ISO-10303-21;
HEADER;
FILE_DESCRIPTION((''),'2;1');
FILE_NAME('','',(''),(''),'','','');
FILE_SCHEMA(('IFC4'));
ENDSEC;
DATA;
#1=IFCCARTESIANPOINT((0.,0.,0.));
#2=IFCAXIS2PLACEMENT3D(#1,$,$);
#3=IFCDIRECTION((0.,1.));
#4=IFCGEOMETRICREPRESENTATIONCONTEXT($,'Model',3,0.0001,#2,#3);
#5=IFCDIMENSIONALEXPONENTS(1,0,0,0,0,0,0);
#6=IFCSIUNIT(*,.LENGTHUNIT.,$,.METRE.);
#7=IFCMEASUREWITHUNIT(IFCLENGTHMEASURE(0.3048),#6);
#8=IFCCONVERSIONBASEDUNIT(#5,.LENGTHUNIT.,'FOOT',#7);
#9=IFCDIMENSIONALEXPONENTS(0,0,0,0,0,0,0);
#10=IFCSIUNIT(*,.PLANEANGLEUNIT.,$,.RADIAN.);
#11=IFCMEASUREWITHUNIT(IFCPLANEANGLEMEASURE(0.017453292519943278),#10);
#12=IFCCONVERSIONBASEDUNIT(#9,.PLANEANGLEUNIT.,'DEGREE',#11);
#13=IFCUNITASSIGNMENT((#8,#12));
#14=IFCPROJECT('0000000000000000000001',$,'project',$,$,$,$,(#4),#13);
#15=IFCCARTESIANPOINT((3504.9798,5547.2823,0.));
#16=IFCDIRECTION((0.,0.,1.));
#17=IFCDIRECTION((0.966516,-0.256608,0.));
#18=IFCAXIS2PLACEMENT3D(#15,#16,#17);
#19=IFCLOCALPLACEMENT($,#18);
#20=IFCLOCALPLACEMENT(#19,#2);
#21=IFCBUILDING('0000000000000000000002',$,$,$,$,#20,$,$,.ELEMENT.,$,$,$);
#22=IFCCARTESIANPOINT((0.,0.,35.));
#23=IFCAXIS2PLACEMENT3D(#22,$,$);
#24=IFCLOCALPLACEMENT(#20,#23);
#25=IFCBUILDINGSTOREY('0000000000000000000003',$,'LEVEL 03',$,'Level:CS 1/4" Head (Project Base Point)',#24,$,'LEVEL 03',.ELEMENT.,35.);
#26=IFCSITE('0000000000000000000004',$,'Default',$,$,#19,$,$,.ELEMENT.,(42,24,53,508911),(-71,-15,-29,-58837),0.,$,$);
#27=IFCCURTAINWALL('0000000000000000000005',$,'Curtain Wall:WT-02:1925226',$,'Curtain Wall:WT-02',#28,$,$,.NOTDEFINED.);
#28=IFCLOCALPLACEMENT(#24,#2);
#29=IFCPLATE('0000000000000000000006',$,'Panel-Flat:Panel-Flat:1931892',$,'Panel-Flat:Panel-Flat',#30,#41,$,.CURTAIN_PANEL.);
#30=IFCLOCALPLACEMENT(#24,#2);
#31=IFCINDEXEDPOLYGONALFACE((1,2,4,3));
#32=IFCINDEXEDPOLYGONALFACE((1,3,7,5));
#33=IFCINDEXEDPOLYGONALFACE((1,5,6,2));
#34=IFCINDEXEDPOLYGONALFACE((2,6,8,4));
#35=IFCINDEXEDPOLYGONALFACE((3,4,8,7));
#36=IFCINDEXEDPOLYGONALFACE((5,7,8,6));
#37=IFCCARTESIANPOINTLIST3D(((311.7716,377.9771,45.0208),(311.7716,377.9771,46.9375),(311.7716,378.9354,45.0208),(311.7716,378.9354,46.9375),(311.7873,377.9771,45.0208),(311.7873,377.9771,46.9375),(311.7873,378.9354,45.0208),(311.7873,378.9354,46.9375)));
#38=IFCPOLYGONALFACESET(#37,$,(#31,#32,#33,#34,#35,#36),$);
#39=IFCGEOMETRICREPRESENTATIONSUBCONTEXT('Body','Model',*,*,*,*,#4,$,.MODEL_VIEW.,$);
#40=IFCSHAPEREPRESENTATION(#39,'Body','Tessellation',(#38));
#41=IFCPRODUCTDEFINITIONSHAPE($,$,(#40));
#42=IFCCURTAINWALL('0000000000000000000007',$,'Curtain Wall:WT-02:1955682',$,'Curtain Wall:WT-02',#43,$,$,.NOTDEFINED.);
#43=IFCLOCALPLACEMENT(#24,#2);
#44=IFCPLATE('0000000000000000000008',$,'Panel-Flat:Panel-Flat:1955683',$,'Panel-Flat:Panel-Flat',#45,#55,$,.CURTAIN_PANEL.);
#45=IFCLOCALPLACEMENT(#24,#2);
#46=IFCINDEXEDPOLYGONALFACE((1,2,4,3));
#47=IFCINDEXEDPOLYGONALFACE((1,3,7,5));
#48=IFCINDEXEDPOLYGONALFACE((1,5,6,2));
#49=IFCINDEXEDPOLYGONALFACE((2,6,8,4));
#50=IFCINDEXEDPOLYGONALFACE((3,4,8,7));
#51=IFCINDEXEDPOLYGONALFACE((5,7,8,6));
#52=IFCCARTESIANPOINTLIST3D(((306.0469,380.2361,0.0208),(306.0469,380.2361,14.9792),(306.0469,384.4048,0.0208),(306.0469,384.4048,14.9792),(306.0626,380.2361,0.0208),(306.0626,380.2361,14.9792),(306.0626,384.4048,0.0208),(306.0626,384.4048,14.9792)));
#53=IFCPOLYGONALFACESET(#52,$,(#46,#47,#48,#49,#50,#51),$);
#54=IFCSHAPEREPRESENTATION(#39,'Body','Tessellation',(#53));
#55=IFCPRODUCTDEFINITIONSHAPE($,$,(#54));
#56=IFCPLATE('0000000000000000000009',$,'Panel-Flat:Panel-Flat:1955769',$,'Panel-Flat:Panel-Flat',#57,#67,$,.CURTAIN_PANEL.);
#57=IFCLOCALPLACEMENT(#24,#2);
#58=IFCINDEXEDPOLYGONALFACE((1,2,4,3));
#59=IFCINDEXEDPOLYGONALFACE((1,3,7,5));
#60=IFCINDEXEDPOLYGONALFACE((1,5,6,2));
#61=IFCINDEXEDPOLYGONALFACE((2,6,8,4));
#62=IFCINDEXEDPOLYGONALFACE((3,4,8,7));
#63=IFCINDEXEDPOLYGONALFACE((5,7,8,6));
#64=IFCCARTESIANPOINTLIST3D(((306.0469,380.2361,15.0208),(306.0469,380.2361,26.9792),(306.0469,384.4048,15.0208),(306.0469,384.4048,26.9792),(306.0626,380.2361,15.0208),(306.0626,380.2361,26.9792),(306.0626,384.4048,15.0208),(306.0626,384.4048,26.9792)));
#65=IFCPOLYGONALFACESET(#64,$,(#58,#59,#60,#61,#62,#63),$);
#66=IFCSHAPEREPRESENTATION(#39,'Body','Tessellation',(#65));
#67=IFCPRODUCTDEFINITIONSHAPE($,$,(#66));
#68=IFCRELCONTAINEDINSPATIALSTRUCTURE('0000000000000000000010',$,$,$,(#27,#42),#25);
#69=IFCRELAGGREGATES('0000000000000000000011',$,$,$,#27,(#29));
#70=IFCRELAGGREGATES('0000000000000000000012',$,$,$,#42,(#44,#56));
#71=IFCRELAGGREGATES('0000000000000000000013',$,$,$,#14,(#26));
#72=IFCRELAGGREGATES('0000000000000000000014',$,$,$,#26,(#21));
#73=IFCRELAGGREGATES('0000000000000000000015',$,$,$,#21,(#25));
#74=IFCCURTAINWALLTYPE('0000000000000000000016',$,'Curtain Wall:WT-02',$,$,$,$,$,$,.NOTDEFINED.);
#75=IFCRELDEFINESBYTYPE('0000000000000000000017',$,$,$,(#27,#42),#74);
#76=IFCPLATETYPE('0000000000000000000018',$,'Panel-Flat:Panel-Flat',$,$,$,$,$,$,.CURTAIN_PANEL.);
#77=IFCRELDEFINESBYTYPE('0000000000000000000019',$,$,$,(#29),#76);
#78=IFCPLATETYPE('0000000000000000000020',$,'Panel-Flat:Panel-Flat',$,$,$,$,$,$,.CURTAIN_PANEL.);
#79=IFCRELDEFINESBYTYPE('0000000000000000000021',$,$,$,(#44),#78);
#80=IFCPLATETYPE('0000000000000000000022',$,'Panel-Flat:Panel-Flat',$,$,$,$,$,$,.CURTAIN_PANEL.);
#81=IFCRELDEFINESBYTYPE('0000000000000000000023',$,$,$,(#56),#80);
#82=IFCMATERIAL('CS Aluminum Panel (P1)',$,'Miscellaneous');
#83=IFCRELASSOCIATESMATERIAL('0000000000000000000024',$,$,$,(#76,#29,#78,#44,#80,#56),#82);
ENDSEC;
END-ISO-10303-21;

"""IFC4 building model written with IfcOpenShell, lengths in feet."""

from ifc_helpers import new_model, entity, si_unit, converted_unit, direction, frame, origin, place, context, subcontext, project, spatial, indexed_curve, outline, extrude, source, transform, mapped, material, type_object, type_shapes, element, aggregate, save


model = new_model("IFC4")

# Units and contexts
model_context = context("Model", 3, precision=0.0001, world=origin(), true_north=direction((0.0, 1.0)))
body_context = subcontext(model_context, "Body", "Model", "MODEL_VIEW")
ifc_project = project(units=[converted_unit("LENGTHUNIT", "FOOT", entity("IfcLengthMeasure", 0.3048), si_unit("LENGTHUNIT", "METRE"), dimensions=[1, 0, 0, 0, 0, 0, 0]), converted_unit("PLANEANGLEUNIT", "DEGREE", entity("IfcPlaneAngleMeasure", 0.017453292519943278), si_unit("PLANEANGLEUNIT", "RADIAN"), dimensions=[0, 0, 0, 0, 0, 0, 0])], contexts=[model_context])

# Site, building, storey
site_placement = place(None, frame((3504.9798, 5547.2823, 0.0), z_axis=(0.0, 0.0, 1.0), x_axis=(0.966516, -0.256608, 0.0)))
site = spatial("IfcSite", under=ifc_project, at=site_placement, Name="Default", CompositionType="ELEMENT", RefLatitude=(42, 24, 53, 508911), RefLongitude=(-71, -15, -29, -58837), RefElevation=0.0)
building_placement = place(site_placement, origin())
building = spatial("IfcBuilding", under=site, at=building_placement, CompositionType="ELEMENT")
storey_placement = place(building_placement, frame((0.0, 0.0, 35.0)))
storey = spatial("IfcBuildingStorey", under=building, at=storey_placement, Name="LEVEL 03", ObjectType="Level:CS 1/4\" Head (Project Base Point)", LongName="LEVEL 03", CompositionType="ELEMENT", Elevation=35.0)

# Curtain walls, plates
curtain_wall_type = type_object("IfcCurtainWallType", Name="Curtain Wall:WT-02", PredefinedType="NOTDEFINED")
curtain_wall_1_placement = place(storey_placement, frame((0.0, 0.0, -35.0)))
curtain_wall_1 = element("IfcCurtainWall", 1, at=curtain_wall_1_placement, inside=storey, type_object=curtain_wall_type, Name="Curtain Wall:WT-02:1925226", ObjectType="Curtain Wall:WT-02", PredefinedType="NOTDEFINED")
ifc_material_1 = material(Name="CS Aluminum Panel (P1)", Category="Miscellaneous")
plate_type_1 = type_object("IfcPlateType", Name="Panel-Flat:Panel-Flat", PredefinedType="CURTAIN_PANEL", material=ifc_material_1)
shared_shape_1 = source(origin(), body_context, "Body", "SweptSolid", [
    extrude(outline(indexed_curve([(-0.0078, -0.4792), (0.0078, -0.4792), (0.0078, 0.4792), (-0.0078, 0.4792), (-0.0078, -0.4792)], self_intersect=False)), frame((0.4792, 0.0078, 0.0), z_axis=(0.0, 0.0, 1.0), x_axis=(0.0, -1.0, 0.0)), (0.0, 0.0, 1.0), 1.9167),
])
type_shapes(plate_type_1, [shared_shape_1])
plate_1_placement = place(curtain_wall_1_placement, frame((311.7716, 378.9354, 80.0208), z_axis=(0.0, 0.0, 1.0), x_axis=(0.0, -1.0, 0.0)))
plate_1 = element("IfcPlate", 2, at=plate_1_placement, type_object=plate_type_1, material=ifc_material_1, Name="Panel-Flat:Panel-Flat:1931892", ObjectType="Panel-Flat:Panel-Flat", PredefinedType="CURTAIN_PANEL", context=body_context, shape_type="MappedRepresentation", body=[
    mapped(shared_shape_1, transform((0.0, 0.0, 0.0), scale=1.0)),
])
aggregate(curtain_wall_1, [plate_1])
curtain_wall_2_placement = place(storey_placement, frame((0.0, 0.0, -35.0)))
curtain_wall_2 = element("IfcCurtainWall", 3, at=curtain_wall_2_placement, inside=storey, type_object=curtain_wall_type, Name="Curtain Wall:WT-02:1955682", ObjectType="Curtain Wall:WT-02", PredefinedType="NOTDEFINED")
plate_type_2 = type_object("IfcPlateType", Name="Panel-Flat:Panel-Flat", PredefinedType="CURTAIN_PANEL", material=ifc_material_1)
shared_shape_2 = source(origin(), body_context, "Body", "SweptSolid", [
    extrude(outline(indexed_curve([(-0.0078, -2.0843), (0.0078, -2.0843), (0.0078, 2.0843), (-0.0078, 2.0843), (-0.0078, -2.0843)], self_intersect=False)), frame((2.0843, 0.0078, 0.0), z_axis=(0.0, 0.0, 1.0), x_axis=(0.0, -1.0, 0.0)), (0.0, 0.0, 1.0), 14.9583),
])
type_shapes(plate_type_2, [shared_shape_2])
plate_2_placement = place(curtain_wall_2_placement, frame((306.0626, 380.2361, 35.0208), z_axis=(0.0, 0.0, 1.0), x_axis=(0.0, 1.0, 0.0)))
plate_2 = element("IfcPlate", 4, at=plate_2_placement, type_object=plate_type_2, material=ifc_material_1, Name="Panel-Flat:Panel-Flat:1955683", ObjectType="Panel-Flat:Panel-Flat", PredefinedType="CURTAIN_PANEL", context=body_context, shape_type="MappedRepresentation", body=[
    mapped(shared_shape_2, transform((0.0, 0.0, 0.0), scale=1.0)),
])
plate_type_3 = type_object("IfcPlateType", Name="Panel-Flat:Panel-Flat", PredefinedType="CURTAIN_PANEL", material=ifc_material_1)
shared_shape_3 = source(origin(), body_context, "Body", "SweptSolid", [
    extrude(outline(indexed_curve([(-0.0078, -2.0843), (0.0078, -2.0843), (0.0078, 2.0843), (-0.0078, 2.0843), (-0.0078, -2.0843)], self_intersect=False)), frame((2.0843, 0.0078, 0.0), z_axis=(0.0, 0.0, 1.0), x_axis=(0.0, -1.0, 0.0)), (0.0, 0.0, 1.0), 11.9583),
])
type_shapes(plate_type_3, [shared_shape_3])
plate_3_placement = place(curtain_wall_2_placement, frame((306.0626, 380.2361, 50.0208), z_axis=(0.0, 0.0, 1.0), x_axis=(0.0, 1.0, 0.0)))
plate_3 = element("IfcPlate", 5, at=plate_3_placement, type_object=plate_type_3, material=ifc_material_1, Name="Panel-Flat:Panel-Flat:1955769", ObjectType="Panel-Flat:Panel-Flat", PredefinedType="CURTAIN_PANEL", context=body_context, shape_type="MappedRepresentation", body=[
    mapped(shared_shape_3, transform((0.0, 0.0, 0.0), scale=1.0)),
])
aggregate(curtain_wall_2, [plate_2, plate_3])

save(model, "model.ifc")
